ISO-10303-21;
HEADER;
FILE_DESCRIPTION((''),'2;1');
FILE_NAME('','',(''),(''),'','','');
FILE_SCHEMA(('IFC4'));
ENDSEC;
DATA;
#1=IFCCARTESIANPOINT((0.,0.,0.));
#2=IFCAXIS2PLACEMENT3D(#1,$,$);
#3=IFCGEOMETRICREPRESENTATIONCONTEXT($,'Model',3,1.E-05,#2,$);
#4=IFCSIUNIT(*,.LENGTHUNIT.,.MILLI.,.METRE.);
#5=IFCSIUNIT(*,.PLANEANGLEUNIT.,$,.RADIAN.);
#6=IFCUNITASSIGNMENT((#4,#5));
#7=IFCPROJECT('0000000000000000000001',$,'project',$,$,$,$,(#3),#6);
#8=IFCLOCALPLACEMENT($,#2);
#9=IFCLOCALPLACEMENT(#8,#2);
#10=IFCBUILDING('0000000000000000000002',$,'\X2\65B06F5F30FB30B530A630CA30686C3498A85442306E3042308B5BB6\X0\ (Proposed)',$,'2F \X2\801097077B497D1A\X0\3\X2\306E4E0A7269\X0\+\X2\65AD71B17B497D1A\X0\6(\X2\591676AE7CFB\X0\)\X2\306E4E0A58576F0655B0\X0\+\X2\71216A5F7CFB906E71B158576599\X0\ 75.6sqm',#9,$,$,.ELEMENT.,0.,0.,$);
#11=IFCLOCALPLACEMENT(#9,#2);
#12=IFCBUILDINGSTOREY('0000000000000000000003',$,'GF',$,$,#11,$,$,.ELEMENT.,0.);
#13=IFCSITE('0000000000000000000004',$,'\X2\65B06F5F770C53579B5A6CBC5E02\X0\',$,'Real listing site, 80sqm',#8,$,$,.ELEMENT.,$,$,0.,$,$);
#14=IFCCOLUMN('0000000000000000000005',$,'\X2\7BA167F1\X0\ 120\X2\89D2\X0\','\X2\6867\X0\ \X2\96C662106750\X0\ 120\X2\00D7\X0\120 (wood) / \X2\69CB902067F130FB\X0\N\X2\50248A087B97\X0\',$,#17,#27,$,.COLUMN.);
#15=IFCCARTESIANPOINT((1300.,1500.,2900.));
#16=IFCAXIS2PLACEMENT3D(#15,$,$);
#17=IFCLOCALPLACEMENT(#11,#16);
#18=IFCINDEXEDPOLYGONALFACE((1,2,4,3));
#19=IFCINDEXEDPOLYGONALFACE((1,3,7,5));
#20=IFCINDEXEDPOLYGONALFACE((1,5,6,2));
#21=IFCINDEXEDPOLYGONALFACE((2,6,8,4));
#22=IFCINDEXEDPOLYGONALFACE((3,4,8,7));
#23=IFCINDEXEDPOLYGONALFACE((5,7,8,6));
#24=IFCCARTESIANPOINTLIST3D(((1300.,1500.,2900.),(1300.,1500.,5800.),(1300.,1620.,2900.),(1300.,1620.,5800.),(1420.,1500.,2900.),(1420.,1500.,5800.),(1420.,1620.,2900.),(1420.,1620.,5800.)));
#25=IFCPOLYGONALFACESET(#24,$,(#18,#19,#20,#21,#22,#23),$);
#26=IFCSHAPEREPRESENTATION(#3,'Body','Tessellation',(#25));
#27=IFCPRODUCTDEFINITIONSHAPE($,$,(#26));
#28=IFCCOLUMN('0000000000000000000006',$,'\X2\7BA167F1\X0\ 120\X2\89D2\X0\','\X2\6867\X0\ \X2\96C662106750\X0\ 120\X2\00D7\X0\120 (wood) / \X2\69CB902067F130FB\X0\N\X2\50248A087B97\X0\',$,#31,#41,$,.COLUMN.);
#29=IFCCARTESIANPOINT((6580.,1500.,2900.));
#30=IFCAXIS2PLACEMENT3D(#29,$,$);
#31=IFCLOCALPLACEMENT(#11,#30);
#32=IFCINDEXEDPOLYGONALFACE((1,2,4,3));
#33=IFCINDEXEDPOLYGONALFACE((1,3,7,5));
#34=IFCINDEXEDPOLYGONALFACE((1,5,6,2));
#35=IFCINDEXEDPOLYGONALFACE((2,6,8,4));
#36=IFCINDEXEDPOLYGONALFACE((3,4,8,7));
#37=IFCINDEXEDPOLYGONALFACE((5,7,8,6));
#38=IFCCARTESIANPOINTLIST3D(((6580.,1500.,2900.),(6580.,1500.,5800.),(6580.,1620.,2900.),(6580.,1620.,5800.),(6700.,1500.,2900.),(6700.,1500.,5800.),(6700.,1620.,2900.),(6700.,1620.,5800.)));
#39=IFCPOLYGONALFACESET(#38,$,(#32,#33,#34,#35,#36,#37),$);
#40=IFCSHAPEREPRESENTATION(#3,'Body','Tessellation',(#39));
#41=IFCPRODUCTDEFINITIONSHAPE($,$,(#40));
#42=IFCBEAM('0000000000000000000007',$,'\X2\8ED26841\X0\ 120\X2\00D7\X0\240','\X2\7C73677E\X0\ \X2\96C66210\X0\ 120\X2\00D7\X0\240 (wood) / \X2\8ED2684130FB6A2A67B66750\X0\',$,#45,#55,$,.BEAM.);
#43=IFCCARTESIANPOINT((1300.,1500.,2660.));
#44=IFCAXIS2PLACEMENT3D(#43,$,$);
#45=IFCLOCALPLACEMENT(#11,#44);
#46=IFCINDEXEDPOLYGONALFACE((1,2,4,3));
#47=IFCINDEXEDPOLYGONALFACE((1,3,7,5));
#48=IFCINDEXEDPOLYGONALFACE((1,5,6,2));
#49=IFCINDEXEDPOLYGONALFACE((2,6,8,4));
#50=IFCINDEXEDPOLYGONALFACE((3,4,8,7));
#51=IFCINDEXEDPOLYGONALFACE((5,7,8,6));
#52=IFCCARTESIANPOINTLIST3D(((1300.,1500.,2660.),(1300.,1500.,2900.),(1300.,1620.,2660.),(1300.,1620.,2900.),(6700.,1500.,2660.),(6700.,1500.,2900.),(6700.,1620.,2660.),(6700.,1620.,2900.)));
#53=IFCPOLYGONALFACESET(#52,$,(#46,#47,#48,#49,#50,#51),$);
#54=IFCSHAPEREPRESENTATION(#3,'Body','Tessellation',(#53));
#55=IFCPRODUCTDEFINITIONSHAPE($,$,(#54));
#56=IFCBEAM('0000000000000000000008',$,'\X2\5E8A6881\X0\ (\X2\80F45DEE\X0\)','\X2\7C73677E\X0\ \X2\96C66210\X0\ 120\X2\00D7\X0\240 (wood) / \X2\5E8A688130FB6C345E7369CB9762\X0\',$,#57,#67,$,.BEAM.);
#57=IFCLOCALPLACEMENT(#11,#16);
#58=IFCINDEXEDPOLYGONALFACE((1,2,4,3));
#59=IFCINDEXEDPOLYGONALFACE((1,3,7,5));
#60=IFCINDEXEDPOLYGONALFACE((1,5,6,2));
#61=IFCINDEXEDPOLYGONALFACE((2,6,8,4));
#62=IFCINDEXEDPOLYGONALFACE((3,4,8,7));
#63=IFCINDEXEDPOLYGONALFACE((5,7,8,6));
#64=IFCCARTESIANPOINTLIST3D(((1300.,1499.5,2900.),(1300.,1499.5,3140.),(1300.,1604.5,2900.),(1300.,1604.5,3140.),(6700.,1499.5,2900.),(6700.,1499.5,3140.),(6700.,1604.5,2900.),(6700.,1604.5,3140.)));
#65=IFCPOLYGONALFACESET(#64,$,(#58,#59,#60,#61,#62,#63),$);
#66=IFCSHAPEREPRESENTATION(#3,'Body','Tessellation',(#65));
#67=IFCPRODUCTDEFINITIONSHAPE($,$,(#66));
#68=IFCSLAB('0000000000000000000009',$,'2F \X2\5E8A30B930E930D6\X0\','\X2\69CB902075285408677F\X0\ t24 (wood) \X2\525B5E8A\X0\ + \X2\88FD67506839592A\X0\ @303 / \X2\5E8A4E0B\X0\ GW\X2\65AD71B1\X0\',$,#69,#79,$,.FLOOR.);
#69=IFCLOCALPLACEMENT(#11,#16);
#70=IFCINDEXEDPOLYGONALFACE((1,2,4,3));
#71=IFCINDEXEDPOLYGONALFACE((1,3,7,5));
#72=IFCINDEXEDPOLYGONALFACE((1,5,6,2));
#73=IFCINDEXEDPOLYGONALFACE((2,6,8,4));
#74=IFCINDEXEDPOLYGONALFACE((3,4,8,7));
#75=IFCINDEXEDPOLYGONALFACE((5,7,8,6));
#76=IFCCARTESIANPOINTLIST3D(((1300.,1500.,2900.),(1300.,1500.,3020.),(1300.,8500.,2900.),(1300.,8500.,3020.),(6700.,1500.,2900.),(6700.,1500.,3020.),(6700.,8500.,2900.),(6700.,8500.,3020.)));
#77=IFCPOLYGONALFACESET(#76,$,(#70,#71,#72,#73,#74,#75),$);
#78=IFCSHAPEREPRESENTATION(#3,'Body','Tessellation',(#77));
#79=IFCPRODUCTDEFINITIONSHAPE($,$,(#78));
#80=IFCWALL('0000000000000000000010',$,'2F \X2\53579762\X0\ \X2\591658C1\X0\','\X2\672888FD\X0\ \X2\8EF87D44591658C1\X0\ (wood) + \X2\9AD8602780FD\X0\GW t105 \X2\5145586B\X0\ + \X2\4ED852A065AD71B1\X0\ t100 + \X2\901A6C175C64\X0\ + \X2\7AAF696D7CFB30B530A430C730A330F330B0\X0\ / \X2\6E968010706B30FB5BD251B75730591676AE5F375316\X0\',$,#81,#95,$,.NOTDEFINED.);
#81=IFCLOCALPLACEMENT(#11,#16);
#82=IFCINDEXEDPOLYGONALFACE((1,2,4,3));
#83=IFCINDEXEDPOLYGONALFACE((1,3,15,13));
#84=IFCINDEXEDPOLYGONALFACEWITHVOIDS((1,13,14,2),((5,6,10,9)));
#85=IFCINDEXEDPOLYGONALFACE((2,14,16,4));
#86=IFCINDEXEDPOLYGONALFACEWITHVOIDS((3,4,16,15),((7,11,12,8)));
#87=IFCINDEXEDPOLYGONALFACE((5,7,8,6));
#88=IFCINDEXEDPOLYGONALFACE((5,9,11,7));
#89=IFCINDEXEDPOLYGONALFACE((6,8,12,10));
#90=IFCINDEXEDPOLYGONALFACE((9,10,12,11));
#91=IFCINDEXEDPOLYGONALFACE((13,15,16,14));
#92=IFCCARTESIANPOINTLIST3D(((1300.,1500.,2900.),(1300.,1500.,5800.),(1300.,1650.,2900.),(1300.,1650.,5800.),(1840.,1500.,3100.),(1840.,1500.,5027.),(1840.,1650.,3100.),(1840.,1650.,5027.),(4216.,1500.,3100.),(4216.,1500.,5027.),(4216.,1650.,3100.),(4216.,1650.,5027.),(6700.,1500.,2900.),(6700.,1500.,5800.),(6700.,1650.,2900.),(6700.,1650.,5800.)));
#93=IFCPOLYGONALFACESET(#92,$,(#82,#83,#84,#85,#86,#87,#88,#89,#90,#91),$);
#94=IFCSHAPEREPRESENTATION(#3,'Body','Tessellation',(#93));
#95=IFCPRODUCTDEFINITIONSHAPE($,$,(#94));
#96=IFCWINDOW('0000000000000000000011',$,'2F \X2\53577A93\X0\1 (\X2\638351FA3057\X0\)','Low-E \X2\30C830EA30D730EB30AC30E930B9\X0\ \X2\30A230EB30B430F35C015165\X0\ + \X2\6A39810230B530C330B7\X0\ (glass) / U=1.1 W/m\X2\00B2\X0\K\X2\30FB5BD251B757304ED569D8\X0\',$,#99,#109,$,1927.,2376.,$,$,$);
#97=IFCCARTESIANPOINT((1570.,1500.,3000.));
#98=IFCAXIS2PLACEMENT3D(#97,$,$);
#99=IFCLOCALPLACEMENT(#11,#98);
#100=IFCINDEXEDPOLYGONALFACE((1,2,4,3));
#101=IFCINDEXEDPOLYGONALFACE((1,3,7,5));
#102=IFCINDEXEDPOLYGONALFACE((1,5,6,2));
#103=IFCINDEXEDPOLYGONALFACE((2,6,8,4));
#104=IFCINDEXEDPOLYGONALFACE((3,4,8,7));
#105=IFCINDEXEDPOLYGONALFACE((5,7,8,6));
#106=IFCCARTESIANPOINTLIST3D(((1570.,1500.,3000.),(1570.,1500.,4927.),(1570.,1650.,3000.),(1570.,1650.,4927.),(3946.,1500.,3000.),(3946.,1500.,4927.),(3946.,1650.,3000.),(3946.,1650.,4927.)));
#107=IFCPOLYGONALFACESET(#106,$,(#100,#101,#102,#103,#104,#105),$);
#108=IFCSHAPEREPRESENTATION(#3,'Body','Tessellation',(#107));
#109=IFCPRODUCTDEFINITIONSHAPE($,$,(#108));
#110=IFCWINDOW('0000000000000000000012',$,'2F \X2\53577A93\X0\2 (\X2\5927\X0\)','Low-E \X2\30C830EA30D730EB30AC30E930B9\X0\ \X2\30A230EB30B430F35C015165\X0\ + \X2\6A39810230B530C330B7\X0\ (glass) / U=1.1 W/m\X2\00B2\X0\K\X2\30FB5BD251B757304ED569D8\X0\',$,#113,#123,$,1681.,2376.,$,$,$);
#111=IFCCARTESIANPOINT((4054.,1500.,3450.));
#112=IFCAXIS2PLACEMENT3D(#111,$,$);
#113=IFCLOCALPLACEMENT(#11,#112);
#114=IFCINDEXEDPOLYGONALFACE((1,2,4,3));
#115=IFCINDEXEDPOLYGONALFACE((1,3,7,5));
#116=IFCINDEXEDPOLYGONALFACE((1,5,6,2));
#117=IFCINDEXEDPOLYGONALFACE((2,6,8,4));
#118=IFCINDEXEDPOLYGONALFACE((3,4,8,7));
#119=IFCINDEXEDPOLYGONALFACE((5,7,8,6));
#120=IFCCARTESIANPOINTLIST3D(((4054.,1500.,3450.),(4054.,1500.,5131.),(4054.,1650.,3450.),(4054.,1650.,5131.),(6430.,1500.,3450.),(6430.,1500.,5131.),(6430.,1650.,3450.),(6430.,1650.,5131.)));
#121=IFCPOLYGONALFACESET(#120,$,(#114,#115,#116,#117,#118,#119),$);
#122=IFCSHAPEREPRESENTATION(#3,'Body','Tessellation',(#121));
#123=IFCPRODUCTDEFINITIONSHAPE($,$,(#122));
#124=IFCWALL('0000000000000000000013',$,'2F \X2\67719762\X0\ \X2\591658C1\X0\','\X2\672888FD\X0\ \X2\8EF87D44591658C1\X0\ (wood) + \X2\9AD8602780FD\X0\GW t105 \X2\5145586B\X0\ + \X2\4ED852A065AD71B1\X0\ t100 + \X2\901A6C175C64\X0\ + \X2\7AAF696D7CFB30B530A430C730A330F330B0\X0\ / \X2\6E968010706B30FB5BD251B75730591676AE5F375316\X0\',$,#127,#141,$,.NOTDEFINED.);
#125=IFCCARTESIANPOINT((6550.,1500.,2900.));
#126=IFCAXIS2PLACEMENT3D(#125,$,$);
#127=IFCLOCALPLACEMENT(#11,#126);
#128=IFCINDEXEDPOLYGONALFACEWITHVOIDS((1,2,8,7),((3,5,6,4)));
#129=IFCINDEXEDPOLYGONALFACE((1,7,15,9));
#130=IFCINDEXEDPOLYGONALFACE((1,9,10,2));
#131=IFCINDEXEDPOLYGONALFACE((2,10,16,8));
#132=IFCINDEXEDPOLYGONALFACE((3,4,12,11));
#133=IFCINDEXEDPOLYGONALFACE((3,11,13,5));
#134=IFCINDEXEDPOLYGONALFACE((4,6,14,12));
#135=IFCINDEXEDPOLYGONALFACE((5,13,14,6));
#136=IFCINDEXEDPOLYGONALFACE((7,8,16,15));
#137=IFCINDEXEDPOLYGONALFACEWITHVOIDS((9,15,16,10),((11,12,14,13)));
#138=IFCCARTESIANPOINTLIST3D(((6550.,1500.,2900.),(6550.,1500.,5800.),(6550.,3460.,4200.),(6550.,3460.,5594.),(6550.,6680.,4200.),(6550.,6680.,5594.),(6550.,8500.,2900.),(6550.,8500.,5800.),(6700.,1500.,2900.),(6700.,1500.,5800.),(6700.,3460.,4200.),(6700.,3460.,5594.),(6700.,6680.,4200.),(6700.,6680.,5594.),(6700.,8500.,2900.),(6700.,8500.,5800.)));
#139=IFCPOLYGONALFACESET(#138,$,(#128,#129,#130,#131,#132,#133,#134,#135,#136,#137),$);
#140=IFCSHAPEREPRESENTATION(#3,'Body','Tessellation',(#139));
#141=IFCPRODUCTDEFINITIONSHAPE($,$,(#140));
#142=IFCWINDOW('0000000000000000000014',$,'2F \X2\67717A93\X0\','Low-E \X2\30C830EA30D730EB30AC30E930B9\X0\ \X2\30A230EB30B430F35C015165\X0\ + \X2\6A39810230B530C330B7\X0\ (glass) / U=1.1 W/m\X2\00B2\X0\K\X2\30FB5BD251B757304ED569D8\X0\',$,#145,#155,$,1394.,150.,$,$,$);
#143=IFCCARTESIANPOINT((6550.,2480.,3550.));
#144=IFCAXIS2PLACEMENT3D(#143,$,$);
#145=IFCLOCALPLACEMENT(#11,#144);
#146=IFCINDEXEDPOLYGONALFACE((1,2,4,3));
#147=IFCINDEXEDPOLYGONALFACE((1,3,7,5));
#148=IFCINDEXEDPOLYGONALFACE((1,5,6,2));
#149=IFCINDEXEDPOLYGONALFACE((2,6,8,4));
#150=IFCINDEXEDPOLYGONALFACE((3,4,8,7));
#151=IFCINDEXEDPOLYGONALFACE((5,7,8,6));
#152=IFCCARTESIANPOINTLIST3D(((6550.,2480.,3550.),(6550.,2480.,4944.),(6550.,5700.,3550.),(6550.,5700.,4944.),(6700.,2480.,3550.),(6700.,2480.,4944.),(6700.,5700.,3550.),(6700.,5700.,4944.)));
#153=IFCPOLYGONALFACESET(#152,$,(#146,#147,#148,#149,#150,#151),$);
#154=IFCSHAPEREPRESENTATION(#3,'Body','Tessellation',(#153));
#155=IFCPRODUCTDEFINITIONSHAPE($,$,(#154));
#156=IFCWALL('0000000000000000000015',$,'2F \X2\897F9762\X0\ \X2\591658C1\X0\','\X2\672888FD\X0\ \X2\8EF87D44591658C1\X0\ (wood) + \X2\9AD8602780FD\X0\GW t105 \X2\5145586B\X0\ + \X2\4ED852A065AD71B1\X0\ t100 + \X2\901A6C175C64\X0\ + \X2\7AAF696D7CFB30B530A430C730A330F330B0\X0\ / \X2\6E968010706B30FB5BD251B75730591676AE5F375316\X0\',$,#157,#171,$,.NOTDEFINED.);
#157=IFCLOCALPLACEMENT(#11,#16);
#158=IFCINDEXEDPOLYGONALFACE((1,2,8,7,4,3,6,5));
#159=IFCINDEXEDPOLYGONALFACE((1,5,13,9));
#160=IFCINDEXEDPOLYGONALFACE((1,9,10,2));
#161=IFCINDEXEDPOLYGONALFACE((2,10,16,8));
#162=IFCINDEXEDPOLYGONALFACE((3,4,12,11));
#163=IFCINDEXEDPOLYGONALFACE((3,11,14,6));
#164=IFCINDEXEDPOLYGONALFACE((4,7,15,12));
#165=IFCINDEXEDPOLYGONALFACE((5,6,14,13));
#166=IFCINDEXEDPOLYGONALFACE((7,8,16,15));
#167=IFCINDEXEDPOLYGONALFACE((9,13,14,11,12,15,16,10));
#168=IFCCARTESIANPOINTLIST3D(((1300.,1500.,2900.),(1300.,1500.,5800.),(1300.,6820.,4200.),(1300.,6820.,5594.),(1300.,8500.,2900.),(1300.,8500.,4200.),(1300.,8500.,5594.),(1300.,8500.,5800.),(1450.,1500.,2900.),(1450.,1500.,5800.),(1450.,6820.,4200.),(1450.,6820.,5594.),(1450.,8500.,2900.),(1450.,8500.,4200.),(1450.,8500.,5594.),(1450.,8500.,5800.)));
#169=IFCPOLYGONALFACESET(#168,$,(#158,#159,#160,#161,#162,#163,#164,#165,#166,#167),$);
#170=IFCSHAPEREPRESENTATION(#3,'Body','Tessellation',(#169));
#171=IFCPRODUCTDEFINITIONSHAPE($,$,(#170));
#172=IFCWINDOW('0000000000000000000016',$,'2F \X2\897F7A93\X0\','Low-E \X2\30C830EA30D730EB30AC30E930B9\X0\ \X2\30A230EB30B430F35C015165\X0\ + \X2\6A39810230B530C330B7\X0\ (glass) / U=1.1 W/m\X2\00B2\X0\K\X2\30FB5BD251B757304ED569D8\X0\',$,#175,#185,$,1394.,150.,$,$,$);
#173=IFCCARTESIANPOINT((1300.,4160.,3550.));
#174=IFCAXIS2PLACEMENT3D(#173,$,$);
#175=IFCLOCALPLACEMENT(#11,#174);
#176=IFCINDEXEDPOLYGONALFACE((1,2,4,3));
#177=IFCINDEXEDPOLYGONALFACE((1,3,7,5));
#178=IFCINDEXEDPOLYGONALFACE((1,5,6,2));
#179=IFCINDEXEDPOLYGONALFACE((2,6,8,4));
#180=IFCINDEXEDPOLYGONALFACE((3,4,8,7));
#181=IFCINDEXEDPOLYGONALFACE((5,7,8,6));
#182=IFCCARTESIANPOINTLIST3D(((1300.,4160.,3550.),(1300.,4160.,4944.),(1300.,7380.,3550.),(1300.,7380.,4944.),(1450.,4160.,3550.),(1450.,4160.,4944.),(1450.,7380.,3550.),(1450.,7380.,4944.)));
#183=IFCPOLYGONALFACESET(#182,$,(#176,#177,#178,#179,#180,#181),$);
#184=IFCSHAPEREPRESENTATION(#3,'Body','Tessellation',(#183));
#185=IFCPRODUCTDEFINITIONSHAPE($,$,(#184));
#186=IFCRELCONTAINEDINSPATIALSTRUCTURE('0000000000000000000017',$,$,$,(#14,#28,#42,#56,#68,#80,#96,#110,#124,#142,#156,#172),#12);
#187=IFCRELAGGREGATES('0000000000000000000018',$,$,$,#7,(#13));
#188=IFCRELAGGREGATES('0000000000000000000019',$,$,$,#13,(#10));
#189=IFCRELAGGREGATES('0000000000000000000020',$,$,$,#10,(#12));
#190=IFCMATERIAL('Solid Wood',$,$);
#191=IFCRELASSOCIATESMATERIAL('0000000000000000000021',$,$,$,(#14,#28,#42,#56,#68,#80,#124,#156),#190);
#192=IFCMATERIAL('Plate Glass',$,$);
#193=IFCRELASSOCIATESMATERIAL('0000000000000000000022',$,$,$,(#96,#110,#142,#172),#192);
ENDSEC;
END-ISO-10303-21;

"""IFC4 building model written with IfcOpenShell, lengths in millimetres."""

from ifc_helpers import new_model, si_unit, frame, frame_2d, origin, place, context, project, spatial, rectangle, extrude, material, element, fill, save


model = new_model("IFC4")

# Units and contexts
model_context = context("Model", 3, precision=1e-05, world=origin())
ifc_project = project(units=[si_unit("LENGTHUNIT", "METRE", prefix="MILLI"), si_unit("PLANEANGLEUNIT", "RADIAN")], contexts=[model_context])

# Site, building, storey
site_placement = place(None, origin())
site = spatial("IfcSite", under=ifc_project, at=site_placement, Name="新潟県南魚沼市", ObjectType="Real listing site, 80sqm", CompositionType="ELEMENT", RefElevation=0.0)
building_placement = place(site_placement, origin())
building = spatial("IfcBuilding", under=site, at=building_placement, Name="新潟・サウナと水風呂のある家 (Proposed)", ObjectType="2F 耐震等級3の上物+断熱等級6(外皮系)の上塗漆喰+無機系遮熱塗料 75.6sqm", CompositionType="ELEMENT", ElevationOfRefHeight=0.0, ElevationOfTerrain=0.0)
storey_placement = place(building_placement, origin())
storey = spatial("IfcBuildingStorey", under=building, at=storey_placement, Name="GF", CompositionType="ELEMENT", Elevation=0.0)

# Columns
ifc_material_1 = material(Name="Solid Wood")
column_1_placement = place(storey_placement, frame((1300.0, 1500.0, 2900.0)))
element("IfcColumn", 1, at=column_1_placement, inside=storey, material=ifc_material_1, Name="管柱 120角", Description="桧 集成材 120×120 (wood) / 構造柱・N値計算", PredefinedType="COLUMN", context=model_context, shape_type="SweptSolid", body=[
    extrude(rectangle(XDim=120.0, YDim=120.0, at=frame_2d((60.0, 60.0))), frame((1300.0, 1500.0, 2900.0)), (0.0, 0.0, 1.0), 2900.0),
])
column_2_placement = place(storey_placement, frame((6580.0, 1500.0, 2900.0)))
element("IfcColumn", 2, at=column_2_placement, inside=storey, material=ifc_material_1, Name="管柱 120角", Description="桧 集成材 120×120 (wood) / 構造柱・N値計算", PredefinedType="COLUMN", context=model_context, shape_type="SweptSolid", body=[
    extrude(rectangle(XDim=120.0, YDim=120.0, at=frame_2d((60.0, 60.0))), frame((6580.0, 1500.0, 2900.0)), (0.0, 0.0, 1.0), 2900.0),
])

# Beams
beam_1_placement = place(storey_placement, frame((1300.0, 1500.0, 2660.0)))
element("IfcBeam", 3, at=beam_1_placement, inside=storey, material=ifc_material_1, Name="軒桁 120×240", Description="米松 集成 120×240 (wood) / 軒桁・横架材", PredefinedType="BEAM", context=model_context, shape_type="SweptSolid", body=[
    extrude(rectangle(XDim=5400.0, YDim=120.0, at=frame_2d((2700.0, 60.0))), frame((1300.0, 1500.0, 2660.0)), (0.0, 0.0, 1.0), 240.0),
])
beam_2_placement = place(storey_placement, frame((1300.0, 1500.0, 2900.0)))
element("IfcBeam", 4, at=beam_2_placement, inside=storey, material=ifc_material_1, Name="床梁 (胴差)", Description="米松 集成 120×240 (wood) / 床梁・水平構面", PredefinedType="BEAM", context=model_context, shape_type="SweptSolid", body=[
    extrude(rectangle(XDim=5400.0, YDim=105.0, at=frame_2d((2700.0, 52.0))), frame((1300.0, 1500.0, 2900.0)), (0.0, 0.0, 1.0), 240.0),
])

# Slab
slab_placement = place(storey_placement, frame((1300.0, 1500.0, 2900.0)))
element("IfcSlab", 5, at=slab_placement, inside=storey, material=ifc_material_1, Name="2F 床スラブ", Description="構造用合板 t24 (wood) 剛床 + 製材根太 @303 / 床下 GW断熱", PredefinedType="FLOOR", context=model_context, shape_type="SweptSolid", body=[
    extrude(rectangle(XDim=5400.0, YDim=7000.0, at=frame_2d((2700.0, 3500.0))), frame((1300.0, 1500.0, 2900.0)), (0.0, 0.0, 1.0), 120.0),
])

# Wall, openings, windows
wall_1_placement = place(storey_placement, frame((1300.0, 1500.0, 2900.0)))
wall_1 = element("IfcWall", 6, at=wall_1_placement, inside=storey, material=ifc_material_1, Name="2F 南面 外壁", Description="木製 軸組外壁 (wood) + 高性能GW t105 充填 + 付加断熱 t100 + 通気層 + 窯業系サイディング / 準耐火・寒冷地外皮強化", PredefinedType="NOTDEFINED", context=model_context, shape_type="SweptSolid", body=[
    extrude(rectangle(XDim=5400.0, YDim=150.0, at=frame_2d((2700.0, 75.0))), frame((1300.0, 1500.0, 2900.0)), (0.0, 0.0, 1.0), 2900.0),
])
opening_1_placement = place(storey_placement, frame((1570.0, 1500.0, 3000.0)))
opening_1 = element("IfcOpeningElement", 7, at=opening_1_placement, cuts=wall_1, PredefinedType="NOTDEFINED", context=model_context, shape_type="SweptSolid", body=[
    extrude(rectangle(XDim=2376.0, YDim=150.0, at=frame_2d((1188.0, 75.0))), frame((1570.0, 1500.0, 3000.0)), (0.0, 0.0, 1.0), 1927.0),
])
opening_2_placement = place(storey_placement, frame((4054.0, 1500.0, 3450.0)))
opening_2 = element("IfcOpeningElement", 8, at=opening_2_placement, cuts=wall_1, PredefinedType="NOTDEFINED", context=model_context, shape_type="SweptSolid", body=[
    extrude(rectangle(XDim=2376.0, YDim=150.0, at=frame_2d((1188.0, 75.0))), frame((4054.0, 1500.0, 3450.0)), (0.0, 0.0, 1.0), 1681.0),
])
ifc_material_2 = material(Name="Plate Glass")
window_1_placement = place(storey_placement, frame((1570.0, 1500.0, 3000.0)))
window_1 = element("IfcWindow", 9, at=window_1_placement, inside=storey, material=ifc_material_2, Name="2F 南窓1 (掃出し)", Description="Low-E トリプルガラス アルゴン封入 + 樹脂サッシ (glass) / U=1.1 W/m²K・寒冷地仕様", OverallHeight=1927.0, OverallWidth=2376.0, context=model_context, shape_type="SweptSolid", body=[
    extrude(rectangle(XDim=2376.0, YDim=150.0, at=frame_2d((1188.0, 75.0))), frame((1570.0, 1500.0, 3000.0)), (0.0, 0.0, 1.0), 1927.0),
])
fill(opening_1, window_1)
window_2_placement = place(storey_placement, frame((4054.0, 1500.0, 3450.0)))
window_2 = element("IfcWindow", 10, at=window_2_placement, inside=storey, material=ifc_material_2, Name="2F 南窓2 (大)", Description="Low-E トリプルガラス アルゴン封入 + 樹脂サッシ (glass) / U=1.1 W/m²K・寒冷地仕様", OverallHeight=1681.0, OverallWidth=2376.0, context=model_context, shape_type="SweptSolid", body=[
    extrude(rectangle(XDim=2376.0, YDim=150.0, at=frame_2d((1188.0, 75.0))), frame((4054.0, 1500.0, 3450.0)), (0.0, 0.0, 1.0), 1681.0),
])
fill(opening_2, window_2)

# Walls, openings, windows
wall_2_placement = place(storey_placement, frame((6550.0, 1500.0, 2900.0)))
wall_2 = element("IfcWall", 11, at=wall_2_placement, inside=storey, material=ifc_material_1, Name="2F 東面 外壁", Description="木製 軸組外壁 (wood) + 高性能GW t105 充填 + 付加断熱 t100 + 通気層 + 窯業系サイディング / 準耐火・寒冷地外皮強化", PredefinedType="NOTDEFINED", context=model_context, shape_type="SweptSolid", body=[
    extrude(rectangle(XDim=150.0, YDim=7000.0, at=frame_2d((75.0, 3500.0))), frame((6550.0, 1500.0, 2900.0)), (0.0, 0.0, 1.0), 2900.0),
])
opening_3_placement = place(storey_placement, frame((6550.0, 2480.0, 3550.0)))
opening_3 = element("IfcOpeningElement", 12, at=opening_3_placement, cuts=wall_2, PredefinedType="NOTDEFINED", context=model_context, shape_type="SweptSolid", body=[
    extrude(rectangle(XDim=150.0, YDim=3220.0, at=frame_2d((75.0, 1610.0))), frame((6550.0, 2480.0, 3550.0)), (0.0, 0.0, 1.0), 1394.0),
])
window_3_placement = place(storey_placement, frame((6550.0, 2480.0, 3550.0)))
window_3 = element("IfcWindow", 13, at=window_3_placement, inside=storey, material=ifc_material_2, Name="2F 東窓", Description="Low-E トリプルガラス アルゴン封入 + 樹脂サッシ (glass) / U=1.1 W/m²K・寒冷地仕様", OverallHeight=1394.0, OverallWidth=150.0, context=model_context, shape_type="SweptSolid", body=[
    extrude(rectangle(XDim=150.0, YDim=3220.0, at=frame_2d((75.0, 1610.0))), frame((6550.0, 2480.0, 3550.0)), (0.0, 0.0, 1.0), 1394.0),
])
fill(opening_3, window_3)
wall_3_placement = place(storey_placement, frame((1300.0, 1500.0, 2900.0)))
wall_3 = element("IfcWall", 14, at=wall_3_placement, inside=storey, material=ifc_material_1, Name="2F 西面 外壁", Description="木製 軸組外壁 (wood) + 高性能GW t105 充填 + 付加断熱 t100 + 通気層 + 窯業系サイディング / 準耐火・寒冷地外皮強化", PredefinedType="NOTDEFINED", context=model_context, shape_type="SweptSolid", body=[
    extrude(rectangle(XDim=150.0, YDim=7000.0, at=frame_2d((75.0, 3500.0))), frame((1300.0, 1500.0, 2900.0)), (0.0, 0.0, 1.0), 2900.0),
])
opening_4_placement = place(storey_placement, frame((1300.0, 4160.0, 3550.0)))
opening_4 = element("IfcOpeningElement", 15, at=opening_4_placement, cuts=wall_3, PredefinedType="NOTDEFINED", context=model_context, shape_type="SweptSolid", body=[
    extrude(rectangle(XDim=150.0, YDim=3220.0, at=frame_2d((75.0, 1610.0))), frame((1300.0, 4160.0, 3550.0)), (0.0, 0.0, 1.0), 1394.0),
])
window_4_placement = place(storey_placement, frame((1300.0, 4160.0, 3550.0)))
window_4 = element("IfcWindow", 16, at=window_4_placement, inside=storey, material=ifc_material_2, Name="2F 西窓", Description="Low-E トリプルガラス アルゴン封入 + 樹脂サッシ (glass) / U=1.1 W/m²K・寒冷地仕様", OverallHeight=1394.0, OverallWidth=150.0, context=model_context, shape_type="SweptSolid", body=[
    extrude(rectangle(XDim=150.0, YDim=3220.0, at=frame_2d((75.0, 1610.0))), frame((1300.0, 4160.0, 3550.0)), (0.0, 0.0, 1.0), 1394.0),
])
fill(opening_4, window_4)

save(model, "model.ifc")
